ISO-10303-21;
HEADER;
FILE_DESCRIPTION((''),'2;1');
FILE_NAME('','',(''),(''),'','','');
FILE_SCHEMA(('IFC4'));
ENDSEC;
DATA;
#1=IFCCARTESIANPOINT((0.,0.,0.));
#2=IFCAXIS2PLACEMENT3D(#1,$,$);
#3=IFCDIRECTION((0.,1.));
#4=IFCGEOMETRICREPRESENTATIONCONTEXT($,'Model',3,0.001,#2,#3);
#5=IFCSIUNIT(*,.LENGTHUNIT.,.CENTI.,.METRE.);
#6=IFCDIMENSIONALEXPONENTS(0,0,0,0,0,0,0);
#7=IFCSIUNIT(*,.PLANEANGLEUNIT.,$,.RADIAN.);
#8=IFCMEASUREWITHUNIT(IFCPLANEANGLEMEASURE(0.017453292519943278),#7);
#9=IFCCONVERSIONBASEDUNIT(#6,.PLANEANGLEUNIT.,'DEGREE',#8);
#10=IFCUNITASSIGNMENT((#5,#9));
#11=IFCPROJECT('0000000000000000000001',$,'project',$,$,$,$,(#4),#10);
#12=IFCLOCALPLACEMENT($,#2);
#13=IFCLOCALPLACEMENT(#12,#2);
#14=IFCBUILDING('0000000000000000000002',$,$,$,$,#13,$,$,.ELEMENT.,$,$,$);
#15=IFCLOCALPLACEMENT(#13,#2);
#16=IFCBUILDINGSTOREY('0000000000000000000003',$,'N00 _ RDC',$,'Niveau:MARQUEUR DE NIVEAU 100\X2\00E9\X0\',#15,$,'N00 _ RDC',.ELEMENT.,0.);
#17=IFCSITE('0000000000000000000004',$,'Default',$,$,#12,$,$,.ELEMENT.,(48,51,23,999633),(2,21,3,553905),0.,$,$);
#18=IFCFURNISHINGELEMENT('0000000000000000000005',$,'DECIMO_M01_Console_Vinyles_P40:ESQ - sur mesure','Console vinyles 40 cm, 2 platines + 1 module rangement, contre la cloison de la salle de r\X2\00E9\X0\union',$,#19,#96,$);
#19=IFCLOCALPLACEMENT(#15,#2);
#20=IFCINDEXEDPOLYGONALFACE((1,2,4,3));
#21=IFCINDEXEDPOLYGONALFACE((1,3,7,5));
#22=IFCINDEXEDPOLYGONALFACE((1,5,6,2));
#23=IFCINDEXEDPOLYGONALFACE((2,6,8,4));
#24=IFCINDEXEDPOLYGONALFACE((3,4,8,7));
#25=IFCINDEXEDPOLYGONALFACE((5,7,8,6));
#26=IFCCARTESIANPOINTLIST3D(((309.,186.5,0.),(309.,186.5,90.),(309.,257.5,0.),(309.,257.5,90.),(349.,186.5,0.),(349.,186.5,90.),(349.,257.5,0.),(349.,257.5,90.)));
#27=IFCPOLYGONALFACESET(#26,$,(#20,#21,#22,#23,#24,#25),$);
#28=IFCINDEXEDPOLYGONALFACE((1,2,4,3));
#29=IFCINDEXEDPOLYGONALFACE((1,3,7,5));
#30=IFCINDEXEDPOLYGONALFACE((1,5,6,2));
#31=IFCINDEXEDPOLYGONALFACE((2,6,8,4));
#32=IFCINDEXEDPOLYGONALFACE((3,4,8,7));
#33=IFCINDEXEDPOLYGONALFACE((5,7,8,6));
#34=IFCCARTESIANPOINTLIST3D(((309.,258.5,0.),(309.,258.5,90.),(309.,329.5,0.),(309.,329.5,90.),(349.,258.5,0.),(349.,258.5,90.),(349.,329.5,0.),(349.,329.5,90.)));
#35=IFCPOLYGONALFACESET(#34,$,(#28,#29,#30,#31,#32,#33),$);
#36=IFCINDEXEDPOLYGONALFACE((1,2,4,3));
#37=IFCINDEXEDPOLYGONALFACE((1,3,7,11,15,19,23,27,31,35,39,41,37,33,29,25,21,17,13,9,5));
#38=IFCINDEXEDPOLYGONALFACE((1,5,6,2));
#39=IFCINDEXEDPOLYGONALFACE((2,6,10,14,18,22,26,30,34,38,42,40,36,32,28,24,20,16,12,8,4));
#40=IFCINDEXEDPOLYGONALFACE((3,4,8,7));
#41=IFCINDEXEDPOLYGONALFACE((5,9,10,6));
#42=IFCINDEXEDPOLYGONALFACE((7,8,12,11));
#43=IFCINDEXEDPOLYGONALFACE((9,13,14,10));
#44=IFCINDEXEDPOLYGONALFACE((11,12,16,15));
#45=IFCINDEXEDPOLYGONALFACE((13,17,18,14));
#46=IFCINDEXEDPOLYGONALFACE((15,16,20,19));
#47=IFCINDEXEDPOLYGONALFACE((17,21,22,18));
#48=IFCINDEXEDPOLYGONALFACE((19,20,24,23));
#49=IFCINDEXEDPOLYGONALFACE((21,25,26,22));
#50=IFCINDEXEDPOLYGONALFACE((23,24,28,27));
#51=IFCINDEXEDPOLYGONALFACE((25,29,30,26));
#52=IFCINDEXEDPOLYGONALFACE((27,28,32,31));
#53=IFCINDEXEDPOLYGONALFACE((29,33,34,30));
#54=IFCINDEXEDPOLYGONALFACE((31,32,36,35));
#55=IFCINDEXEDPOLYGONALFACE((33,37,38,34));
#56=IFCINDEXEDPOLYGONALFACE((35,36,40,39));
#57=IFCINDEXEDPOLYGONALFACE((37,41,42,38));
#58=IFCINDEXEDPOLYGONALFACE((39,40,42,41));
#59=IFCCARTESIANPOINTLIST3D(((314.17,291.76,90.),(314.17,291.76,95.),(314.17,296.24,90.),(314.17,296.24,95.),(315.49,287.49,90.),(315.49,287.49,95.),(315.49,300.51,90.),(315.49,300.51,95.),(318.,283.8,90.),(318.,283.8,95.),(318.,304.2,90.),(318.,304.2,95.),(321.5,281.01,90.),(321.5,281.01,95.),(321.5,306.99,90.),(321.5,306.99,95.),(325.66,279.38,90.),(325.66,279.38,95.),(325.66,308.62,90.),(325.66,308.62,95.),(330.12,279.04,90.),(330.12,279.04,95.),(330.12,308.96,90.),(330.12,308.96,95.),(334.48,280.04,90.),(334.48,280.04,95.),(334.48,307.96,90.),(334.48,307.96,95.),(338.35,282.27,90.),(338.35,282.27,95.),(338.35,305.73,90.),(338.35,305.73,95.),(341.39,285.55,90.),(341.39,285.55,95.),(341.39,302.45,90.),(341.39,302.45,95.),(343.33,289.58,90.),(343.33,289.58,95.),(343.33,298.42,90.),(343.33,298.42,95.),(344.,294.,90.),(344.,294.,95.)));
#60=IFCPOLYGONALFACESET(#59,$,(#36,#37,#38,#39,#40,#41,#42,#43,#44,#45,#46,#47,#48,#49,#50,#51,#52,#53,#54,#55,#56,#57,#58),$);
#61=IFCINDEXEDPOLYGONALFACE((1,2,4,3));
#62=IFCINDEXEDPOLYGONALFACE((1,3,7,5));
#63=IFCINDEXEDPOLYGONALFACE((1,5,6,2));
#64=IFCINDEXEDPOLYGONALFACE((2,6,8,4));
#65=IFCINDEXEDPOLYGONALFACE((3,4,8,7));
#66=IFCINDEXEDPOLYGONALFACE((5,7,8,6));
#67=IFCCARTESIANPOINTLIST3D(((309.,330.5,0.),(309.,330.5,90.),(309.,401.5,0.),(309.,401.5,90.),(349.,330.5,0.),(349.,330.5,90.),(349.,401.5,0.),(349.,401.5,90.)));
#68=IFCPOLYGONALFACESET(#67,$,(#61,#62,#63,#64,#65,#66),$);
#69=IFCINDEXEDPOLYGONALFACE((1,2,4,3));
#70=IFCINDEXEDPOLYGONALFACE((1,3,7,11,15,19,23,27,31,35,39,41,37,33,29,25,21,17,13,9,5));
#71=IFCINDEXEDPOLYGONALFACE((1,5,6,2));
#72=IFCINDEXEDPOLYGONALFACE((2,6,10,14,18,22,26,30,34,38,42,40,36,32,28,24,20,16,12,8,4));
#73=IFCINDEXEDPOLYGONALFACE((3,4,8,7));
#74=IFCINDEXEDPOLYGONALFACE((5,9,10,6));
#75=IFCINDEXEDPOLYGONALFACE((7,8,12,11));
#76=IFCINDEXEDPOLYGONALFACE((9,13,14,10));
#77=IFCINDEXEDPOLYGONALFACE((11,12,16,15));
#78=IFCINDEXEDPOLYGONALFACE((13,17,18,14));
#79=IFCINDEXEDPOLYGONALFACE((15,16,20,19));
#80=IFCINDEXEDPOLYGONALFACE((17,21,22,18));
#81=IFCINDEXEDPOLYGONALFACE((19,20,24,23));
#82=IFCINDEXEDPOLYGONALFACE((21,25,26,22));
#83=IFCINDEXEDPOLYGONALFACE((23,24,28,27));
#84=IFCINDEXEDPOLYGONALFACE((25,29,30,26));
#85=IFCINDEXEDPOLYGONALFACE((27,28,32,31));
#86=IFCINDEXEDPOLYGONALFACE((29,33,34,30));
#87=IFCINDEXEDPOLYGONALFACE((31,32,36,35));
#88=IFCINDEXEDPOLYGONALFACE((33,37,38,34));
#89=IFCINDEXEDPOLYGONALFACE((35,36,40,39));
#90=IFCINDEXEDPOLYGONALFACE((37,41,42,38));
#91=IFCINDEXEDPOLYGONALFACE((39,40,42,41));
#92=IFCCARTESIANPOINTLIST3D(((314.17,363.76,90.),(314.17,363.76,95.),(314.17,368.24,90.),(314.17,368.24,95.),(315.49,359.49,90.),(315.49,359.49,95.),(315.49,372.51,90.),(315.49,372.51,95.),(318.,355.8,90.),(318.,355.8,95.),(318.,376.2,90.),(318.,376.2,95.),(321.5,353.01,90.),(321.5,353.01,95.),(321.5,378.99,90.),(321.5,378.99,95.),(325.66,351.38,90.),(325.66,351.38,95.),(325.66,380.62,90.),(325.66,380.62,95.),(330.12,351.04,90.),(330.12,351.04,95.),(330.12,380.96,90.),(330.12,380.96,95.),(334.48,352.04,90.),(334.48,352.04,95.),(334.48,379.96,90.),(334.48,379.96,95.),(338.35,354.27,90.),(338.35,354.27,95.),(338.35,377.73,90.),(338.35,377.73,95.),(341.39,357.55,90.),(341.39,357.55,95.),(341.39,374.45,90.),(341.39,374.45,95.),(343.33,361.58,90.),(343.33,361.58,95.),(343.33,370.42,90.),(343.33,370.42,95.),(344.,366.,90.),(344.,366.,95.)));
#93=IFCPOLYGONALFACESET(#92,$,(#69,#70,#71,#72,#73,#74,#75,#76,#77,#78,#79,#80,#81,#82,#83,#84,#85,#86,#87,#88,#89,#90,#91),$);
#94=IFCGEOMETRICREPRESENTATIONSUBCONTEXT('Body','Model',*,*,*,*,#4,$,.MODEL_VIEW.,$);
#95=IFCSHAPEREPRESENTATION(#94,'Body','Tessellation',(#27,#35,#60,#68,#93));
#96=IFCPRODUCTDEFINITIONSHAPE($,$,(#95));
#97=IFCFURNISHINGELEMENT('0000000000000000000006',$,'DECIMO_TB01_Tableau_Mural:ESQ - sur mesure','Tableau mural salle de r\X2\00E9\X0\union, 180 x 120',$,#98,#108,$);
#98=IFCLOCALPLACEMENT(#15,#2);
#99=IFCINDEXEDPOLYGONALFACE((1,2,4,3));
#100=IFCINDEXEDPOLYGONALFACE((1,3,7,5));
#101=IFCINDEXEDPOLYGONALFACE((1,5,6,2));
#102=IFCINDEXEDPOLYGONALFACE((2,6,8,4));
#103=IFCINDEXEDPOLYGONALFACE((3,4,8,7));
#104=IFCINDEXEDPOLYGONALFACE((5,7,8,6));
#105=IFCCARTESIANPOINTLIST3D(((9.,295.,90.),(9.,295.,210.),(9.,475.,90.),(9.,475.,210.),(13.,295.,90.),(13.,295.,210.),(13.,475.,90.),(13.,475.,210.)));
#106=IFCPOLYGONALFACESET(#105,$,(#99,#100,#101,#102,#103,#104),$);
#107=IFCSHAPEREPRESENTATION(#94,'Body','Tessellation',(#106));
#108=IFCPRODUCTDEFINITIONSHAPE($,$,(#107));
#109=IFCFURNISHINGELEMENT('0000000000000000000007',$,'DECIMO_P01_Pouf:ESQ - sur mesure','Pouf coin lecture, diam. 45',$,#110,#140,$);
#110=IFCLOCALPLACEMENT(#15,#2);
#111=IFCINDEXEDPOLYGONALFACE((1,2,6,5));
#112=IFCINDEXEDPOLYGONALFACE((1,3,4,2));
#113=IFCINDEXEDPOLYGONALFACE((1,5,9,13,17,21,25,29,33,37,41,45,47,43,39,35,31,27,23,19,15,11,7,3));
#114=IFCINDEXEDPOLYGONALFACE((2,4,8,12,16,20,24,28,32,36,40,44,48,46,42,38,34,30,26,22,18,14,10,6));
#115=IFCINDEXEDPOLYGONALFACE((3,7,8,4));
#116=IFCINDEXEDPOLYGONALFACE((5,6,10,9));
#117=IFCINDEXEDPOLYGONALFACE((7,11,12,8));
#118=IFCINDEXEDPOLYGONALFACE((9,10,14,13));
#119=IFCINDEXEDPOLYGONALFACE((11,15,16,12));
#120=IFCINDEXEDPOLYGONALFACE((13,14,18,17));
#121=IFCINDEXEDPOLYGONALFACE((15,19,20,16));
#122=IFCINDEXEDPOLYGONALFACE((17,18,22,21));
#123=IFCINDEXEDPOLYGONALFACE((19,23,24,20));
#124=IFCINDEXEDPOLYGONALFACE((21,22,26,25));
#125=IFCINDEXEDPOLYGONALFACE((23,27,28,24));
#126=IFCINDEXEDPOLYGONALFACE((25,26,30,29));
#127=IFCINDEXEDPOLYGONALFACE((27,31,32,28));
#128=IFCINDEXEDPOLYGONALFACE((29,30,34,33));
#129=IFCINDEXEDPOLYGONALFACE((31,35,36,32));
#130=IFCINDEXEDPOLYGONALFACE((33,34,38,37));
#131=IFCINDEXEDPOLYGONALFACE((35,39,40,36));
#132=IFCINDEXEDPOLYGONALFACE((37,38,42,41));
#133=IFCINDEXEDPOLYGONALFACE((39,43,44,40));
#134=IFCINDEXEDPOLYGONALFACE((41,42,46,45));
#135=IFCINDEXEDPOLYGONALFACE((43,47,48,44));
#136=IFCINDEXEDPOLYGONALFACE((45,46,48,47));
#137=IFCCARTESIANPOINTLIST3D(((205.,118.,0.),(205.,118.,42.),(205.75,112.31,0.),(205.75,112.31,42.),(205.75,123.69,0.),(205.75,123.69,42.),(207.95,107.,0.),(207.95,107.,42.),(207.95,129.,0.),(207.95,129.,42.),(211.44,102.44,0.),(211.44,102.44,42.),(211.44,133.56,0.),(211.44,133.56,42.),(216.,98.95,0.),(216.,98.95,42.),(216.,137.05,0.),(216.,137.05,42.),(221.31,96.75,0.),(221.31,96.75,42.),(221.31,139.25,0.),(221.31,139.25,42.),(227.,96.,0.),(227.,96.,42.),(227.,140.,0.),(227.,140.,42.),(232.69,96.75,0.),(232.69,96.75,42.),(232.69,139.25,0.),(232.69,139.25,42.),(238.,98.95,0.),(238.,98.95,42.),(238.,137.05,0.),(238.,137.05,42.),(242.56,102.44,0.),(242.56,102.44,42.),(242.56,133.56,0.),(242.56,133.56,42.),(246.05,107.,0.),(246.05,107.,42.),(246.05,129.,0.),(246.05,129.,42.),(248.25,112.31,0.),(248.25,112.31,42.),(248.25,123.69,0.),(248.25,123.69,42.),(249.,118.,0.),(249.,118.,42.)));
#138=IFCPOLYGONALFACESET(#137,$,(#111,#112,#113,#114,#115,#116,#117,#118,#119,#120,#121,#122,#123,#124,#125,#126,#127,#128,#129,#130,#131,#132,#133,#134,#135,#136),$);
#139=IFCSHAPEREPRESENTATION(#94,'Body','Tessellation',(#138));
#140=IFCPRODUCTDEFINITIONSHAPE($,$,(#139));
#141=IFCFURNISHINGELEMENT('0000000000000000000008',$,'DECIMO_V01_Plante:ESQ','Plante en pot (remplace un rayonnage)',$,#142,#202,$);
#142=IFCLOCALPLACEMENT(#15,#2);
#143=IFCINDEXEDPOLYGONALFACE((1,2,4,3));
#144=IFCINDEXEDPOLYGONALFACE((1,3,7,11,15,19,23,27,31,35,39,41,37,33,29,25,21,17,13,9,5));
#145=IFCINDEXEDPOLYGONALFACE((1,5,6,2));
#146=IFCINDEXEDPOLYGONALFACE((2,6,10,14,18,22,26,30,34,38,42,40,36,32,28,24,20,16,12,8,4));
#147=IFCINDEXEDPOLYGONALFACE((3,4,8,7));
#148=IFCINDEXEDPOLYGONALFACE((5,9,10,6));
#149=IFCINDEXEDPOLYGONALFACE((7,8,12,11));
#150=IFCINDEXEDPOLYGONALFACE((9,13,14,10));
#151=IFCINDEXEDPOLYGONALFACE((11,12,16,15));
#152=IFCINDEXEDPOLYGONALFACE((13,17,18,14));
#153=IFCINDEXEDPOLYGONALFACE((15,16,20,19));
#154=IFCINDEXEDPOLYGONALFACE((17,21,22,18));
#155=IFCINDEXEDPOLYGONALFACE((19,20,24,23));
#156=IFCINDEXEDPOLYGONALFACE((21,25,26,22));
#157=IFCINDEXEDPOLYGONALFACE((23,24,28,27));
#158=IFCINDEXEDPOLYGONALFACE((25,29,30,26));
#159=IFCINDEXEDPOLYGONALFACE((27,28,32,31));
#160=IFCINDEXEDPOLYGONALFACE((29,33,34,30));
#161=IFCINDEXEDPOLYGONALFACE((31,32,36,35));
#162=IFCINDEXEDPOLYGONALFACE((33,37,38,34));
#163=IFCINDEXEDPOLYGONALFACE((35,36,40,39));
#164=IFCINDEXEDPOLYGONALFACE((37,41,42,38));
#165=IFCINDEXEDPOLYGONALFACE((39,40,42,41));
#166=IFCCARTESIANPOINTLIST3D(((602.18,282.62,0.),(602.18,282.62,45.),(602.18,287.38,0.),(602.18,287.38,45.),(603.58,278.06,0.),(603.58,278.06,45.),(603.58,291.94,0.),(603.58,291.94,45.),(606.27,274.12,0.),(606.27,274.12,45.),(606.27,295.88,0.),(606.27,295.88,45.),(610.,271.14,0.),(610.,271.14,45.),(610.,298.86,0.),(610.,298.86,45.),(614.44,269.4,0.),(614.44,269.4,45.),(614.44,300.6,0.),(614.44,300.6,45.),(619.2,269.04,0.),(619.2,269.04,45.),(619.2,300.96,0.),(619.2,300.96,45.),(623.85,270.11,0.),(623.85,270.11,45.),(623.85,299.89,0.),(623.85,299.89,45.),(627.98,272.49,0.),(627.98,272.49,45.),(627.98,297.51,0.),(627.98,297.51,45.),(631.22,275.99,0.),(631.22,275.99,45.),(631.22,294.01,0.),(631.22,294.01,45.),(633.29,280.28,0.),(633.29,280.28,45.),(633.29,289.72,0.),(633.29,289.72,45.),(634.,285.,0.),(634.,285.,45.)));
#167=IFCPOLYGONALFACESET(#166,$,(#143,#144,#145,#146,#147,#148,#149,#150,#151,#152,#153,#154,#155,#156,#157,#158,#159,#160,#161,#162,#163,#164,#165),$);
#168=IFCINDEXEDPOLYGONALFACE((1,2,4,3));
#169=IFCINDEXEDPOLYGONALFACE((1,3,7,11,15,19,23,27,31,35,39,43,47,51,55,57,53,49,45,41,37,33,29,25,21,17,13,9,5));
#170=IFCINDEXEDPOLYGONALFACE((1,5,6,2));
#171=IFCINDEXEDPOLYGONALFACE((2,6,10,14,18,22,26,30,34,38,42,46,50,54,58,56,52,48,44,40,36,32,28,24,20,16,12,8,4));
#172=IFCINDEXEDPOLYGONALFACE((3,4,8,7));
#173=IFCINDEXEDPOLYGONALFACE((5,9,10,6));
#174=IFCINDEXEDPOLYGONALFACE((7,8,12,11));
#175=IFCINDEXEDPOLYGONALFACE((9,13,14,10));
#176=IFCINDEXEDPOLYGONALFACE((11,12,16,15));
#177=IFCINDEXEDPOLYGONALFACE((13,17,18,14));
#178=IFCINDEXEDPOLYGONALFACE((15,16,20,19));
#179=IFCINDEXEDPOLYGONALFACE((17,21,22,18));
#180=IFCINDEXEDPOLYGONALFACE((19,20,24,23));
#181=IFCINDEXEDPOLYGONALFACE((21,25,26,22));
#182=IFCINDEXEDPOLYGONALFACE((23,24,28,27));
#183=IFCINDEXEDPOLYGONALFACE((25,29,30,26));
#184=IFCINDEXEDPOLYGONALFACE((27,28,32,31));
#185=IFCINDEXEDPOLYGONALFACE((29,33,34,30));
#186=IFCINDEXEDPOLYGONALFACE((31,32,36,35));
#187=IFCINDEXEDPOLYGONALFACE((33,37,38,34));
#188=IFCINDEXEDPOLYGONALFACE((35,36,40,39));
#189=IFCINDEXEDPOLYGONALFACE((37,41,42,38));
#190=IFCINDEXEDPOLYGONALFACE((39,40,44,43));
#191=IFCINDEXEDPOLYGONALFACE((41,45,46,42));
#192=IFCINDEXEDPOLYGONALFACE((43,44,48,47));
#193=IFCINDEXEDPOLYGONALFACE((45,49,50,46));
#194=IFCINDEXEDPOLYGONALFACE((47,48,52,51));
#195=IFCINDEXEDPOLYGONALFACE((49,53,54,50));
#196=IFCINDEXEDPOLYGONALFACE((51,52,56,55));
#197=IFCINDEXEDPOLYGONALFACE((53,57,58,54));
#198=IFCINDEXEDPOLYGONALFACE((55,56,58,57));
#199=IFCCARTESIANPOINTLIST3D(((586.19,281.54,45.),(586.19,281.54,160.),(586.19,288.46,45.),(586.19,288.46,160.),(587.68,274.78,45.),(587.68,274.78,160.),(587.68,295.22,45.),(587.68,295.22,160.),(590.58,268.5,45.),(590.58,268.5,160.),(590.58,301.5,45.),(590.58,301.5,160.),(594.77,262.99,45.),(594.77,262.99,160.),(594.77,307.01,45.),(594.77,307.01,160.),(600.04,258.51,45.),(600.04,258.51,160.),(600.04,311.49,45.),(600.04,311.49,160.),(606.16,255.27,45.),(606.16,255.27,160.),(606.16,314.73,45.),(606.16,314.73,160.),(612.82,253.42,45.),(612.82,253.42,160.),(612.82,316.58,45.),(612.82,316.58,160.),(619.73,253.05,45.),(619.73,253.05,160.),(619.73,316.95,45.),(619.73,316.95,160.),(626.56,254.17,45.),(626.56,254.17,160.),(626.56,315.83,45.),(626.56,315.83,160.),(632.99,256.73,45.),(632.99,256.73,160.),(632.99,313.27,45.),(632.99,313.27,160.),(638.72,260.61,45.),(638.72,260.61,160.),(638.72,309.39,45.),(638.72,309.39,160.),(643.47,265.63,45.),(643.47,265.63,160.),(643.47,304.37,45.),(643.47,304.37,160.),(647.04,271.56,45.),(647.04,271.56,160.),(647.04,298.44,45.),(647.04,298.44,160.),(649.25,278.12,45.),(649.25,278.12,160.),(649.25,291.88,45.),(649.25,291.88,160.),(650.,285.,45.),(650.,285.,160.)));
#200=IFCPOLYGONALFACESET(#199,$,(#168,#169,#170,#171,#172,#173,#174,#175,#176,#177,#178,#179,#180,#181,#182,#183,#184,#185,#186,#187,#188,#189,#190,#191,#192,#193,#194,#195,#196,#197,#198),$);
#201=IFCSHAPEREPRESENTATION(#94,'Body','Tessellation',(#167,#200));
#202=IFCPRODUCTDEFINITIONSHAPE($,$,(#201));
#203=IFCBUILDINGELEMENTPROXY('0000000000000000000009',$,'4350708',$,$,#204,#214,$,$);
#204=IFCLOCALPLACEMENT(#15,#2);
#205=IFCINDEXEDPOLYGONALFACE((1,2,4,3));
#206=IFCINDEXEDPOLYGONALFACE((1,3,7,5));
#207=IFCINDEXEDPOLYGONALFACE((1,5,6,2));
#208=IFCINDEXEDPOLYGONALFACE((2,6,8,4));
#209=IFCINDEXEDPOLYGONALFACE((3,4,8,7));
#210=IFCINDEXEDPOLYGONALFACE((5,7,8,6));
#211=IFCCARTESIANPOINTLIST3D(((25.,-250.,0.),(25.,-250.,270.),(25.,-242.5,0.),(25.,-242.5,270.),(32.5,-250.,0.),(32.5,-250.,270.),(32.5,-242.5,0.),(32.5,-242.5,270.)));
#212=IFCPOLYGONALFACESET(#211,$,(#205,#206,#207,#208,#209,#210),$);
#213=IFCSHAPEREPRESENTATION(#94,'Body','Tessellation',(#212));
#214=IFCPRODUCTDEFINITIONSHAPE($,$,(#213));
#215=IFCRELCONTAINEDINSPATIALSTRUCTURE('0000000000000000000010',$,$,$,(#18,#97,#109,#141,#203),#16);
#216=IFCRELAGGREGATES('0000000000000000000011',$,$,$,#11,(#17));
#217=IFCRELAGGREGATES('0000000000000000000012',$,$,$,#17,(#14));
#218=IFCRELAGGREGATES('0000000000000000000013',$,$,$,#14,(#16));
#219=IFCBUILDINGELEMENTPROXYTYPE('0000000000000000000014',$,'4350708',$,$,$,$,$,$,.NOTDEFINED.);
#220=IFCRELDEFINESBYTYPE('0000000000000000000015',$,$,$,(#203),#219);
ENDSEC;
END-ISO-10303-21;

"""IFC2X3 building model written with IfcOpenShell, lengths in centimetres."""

from ifc_helpers import new_model, entity, si_unit, converted_unit, direction, frame, frame_2d, origin, origin_with_axes, place, context, subcontext, project, spatial, rectangle, circle, extrude, type_object, element, save


model = new_model("IFC2X3")

# Units and contexts
model_context = context("Model", 3, precision=0.001, world=origin(), true_north=direction((0.0, 1.0)))
body_context = subcontext(model_context, "Body", "Model", "MODEL_VIEW")
ifc_project = project(units=[si_unit("LENGTHUNIT", "METRE", prefix="CENTI"), converted_unit("PLANEANGLEUNIT", "DEGREE", entity("IfcPlaneAngleMeasure", 0.017453292519943278), si_unit("PLANEANGLEUNIT", "RADIAN"), dimensions=[0, 0, 0, 0, 0, 0, 0])], contexts=[model_context])

# Site, building, storey
site_placement = place(None, origin())
site = spatial("IfcSite", under=ifc_project, at=site_placement, Name="Default", CompositionType="ELEMENT", RefLatitude=(48, 51, 23, 999633), RefLongitude=(2, 21, 3, 553905), RefElevation=0.0)
building_placement = place(site_placement, origin())
building = spatial("IfcBuilding", under=site, at=building_placement, CompositionType="ELEMENT")
storey_placement = place(building_placement, origin())
storey = spatial("IfcBuildingStorey", under=building, at=storey_placement, Name="N00 _ RDC", ObjectType="Niveau:MARQUEUR DE NIVEAU 100é", LongName="N00 _ RDC", CompositionType="ELEMENT", Elevation=0.0)

# Furnishing elements
furnishing_1_placement = place(storey_placement, origin_with_axes())
element("IfcFurnishingElement", 1, at=furnishing_1_placement, inside=storey, Name="DECIMO_M01_Console_Vinyles_P40:ESQ - sur mesure", Description="Console vinyles 40 cm, 2 platines + 1 module rangement, contre la cloison de la salle de réunion", context=body_context, shape_type="SweptSolid", body=[
    extrude(rectangle(XDim=40.0, YDim=71.0, at=frame_2d((329.0, 222.0))), origin(), (0.0, 0.0, 1.0), 90.0),
    extrude(rectangle(XDim=40.0, YDim=71.0, at=frame_2d((329.0, 294.0))), origin(), (0.0, 0.0, 1.0), 90.0),
    extrude(circle(Radius=15.0, at=frame_2d((329.0, 294.0))), frame((0.0, 0.0, 90.0)), (0.0, 0.0, 1.0), 5.0),
    extrude(rectangle(XDim=40.0, YDim=71.0, at=frame_2d((329.0, 366.0))), origin(), (0.0, 0.0, 1.0), 90.0),
    extrude(circle(Radius=15.0, at=frame_2d((329.0, 366.0))), frame((0.0, 0.0, 90.0)), (0.0, 0.0, 1.0), 5.0),
])
furnishing_2_placement = place(storey_placement, origin_with_axes())
element("IfcFurnishingElement", 2, at=furnishing_2_placement, inside=storey, Name="DECIMO_TB01_Tableau_Mural:ESQ - sur mesure", Description="Tableau mural salle de réunion, 180 x 120", context=body_context, shape_type="SweptSolid", body=[
    extrude(rectangle(XDim=4.0, YDim=180.0, at=frame_2d((11.0, 385.0))), frame((0.0, 0.0, 90.0)), (0.0, 0.0, 1.0), 120.0),
])
furnishing_3_placement = place(storey_placement, origin_with_axes())
element("IfcFurnishingElement", 3, at=furnishing_3_placement, inside=storey, Name="DECIMO_P01_Pouf:ESQ - sur mesure", Description="Pouf coin lecture, diam. 45", context=body_context, shape_type="SweptSolid", body=[
    extrude(circle(Radius=22.0, at=frame_2d((227.0, 118.0))), origin(), (0.0, 0.0, 1.0), 42.0),
])
furnishing_4_placement = place(storey_placement, origin_with_axes())
element("IfcFurnishingElement", 4, at=furnishing_4_placement, inside=storey, Name="DECIMO_V01_Plante:ESQ", Description="Plante en pot (remplace un rayonnage)", context=body_context, shape_type="SweptSolid", body=[
    extrude(circle(Radius=16.0, at=frame_2d((618.0, 285.0))), origin(), (0.0, 0.0, 1.0), 45.0),
    extrude(circle(Radius=32.0, at=frame_2d((618.0, 285.0))), frame((0.0, 0.0, 45.0)), (0.0, 0.0, 1.0), 115.0),
])

# Building element proxy
building_element_proxy_type_1 = type_object("IfcBuildingElementProxyType", Name="4350708", PredefinedType="NOTDEFINED")
proxy_1_placement = place(storey_placement, origin())
element("IfcBuildingElementProxy", 5, at=proxy_1_placement, inside=storey, type_object=building_element_proxy_type_1, Name="4350708", context=body_context, shape_type="SweptSolid", body=[
    extrude(rectangle(XDim=7.5, YDim=7.5, at=frame_2d((0.0, 0.0), x_axis=(1.0, 0.0))), frame((28.75, -246.25, 0.0)), (0.0, 0.0, 1.0), 270.0),
])

save(model, "model.ifc")
